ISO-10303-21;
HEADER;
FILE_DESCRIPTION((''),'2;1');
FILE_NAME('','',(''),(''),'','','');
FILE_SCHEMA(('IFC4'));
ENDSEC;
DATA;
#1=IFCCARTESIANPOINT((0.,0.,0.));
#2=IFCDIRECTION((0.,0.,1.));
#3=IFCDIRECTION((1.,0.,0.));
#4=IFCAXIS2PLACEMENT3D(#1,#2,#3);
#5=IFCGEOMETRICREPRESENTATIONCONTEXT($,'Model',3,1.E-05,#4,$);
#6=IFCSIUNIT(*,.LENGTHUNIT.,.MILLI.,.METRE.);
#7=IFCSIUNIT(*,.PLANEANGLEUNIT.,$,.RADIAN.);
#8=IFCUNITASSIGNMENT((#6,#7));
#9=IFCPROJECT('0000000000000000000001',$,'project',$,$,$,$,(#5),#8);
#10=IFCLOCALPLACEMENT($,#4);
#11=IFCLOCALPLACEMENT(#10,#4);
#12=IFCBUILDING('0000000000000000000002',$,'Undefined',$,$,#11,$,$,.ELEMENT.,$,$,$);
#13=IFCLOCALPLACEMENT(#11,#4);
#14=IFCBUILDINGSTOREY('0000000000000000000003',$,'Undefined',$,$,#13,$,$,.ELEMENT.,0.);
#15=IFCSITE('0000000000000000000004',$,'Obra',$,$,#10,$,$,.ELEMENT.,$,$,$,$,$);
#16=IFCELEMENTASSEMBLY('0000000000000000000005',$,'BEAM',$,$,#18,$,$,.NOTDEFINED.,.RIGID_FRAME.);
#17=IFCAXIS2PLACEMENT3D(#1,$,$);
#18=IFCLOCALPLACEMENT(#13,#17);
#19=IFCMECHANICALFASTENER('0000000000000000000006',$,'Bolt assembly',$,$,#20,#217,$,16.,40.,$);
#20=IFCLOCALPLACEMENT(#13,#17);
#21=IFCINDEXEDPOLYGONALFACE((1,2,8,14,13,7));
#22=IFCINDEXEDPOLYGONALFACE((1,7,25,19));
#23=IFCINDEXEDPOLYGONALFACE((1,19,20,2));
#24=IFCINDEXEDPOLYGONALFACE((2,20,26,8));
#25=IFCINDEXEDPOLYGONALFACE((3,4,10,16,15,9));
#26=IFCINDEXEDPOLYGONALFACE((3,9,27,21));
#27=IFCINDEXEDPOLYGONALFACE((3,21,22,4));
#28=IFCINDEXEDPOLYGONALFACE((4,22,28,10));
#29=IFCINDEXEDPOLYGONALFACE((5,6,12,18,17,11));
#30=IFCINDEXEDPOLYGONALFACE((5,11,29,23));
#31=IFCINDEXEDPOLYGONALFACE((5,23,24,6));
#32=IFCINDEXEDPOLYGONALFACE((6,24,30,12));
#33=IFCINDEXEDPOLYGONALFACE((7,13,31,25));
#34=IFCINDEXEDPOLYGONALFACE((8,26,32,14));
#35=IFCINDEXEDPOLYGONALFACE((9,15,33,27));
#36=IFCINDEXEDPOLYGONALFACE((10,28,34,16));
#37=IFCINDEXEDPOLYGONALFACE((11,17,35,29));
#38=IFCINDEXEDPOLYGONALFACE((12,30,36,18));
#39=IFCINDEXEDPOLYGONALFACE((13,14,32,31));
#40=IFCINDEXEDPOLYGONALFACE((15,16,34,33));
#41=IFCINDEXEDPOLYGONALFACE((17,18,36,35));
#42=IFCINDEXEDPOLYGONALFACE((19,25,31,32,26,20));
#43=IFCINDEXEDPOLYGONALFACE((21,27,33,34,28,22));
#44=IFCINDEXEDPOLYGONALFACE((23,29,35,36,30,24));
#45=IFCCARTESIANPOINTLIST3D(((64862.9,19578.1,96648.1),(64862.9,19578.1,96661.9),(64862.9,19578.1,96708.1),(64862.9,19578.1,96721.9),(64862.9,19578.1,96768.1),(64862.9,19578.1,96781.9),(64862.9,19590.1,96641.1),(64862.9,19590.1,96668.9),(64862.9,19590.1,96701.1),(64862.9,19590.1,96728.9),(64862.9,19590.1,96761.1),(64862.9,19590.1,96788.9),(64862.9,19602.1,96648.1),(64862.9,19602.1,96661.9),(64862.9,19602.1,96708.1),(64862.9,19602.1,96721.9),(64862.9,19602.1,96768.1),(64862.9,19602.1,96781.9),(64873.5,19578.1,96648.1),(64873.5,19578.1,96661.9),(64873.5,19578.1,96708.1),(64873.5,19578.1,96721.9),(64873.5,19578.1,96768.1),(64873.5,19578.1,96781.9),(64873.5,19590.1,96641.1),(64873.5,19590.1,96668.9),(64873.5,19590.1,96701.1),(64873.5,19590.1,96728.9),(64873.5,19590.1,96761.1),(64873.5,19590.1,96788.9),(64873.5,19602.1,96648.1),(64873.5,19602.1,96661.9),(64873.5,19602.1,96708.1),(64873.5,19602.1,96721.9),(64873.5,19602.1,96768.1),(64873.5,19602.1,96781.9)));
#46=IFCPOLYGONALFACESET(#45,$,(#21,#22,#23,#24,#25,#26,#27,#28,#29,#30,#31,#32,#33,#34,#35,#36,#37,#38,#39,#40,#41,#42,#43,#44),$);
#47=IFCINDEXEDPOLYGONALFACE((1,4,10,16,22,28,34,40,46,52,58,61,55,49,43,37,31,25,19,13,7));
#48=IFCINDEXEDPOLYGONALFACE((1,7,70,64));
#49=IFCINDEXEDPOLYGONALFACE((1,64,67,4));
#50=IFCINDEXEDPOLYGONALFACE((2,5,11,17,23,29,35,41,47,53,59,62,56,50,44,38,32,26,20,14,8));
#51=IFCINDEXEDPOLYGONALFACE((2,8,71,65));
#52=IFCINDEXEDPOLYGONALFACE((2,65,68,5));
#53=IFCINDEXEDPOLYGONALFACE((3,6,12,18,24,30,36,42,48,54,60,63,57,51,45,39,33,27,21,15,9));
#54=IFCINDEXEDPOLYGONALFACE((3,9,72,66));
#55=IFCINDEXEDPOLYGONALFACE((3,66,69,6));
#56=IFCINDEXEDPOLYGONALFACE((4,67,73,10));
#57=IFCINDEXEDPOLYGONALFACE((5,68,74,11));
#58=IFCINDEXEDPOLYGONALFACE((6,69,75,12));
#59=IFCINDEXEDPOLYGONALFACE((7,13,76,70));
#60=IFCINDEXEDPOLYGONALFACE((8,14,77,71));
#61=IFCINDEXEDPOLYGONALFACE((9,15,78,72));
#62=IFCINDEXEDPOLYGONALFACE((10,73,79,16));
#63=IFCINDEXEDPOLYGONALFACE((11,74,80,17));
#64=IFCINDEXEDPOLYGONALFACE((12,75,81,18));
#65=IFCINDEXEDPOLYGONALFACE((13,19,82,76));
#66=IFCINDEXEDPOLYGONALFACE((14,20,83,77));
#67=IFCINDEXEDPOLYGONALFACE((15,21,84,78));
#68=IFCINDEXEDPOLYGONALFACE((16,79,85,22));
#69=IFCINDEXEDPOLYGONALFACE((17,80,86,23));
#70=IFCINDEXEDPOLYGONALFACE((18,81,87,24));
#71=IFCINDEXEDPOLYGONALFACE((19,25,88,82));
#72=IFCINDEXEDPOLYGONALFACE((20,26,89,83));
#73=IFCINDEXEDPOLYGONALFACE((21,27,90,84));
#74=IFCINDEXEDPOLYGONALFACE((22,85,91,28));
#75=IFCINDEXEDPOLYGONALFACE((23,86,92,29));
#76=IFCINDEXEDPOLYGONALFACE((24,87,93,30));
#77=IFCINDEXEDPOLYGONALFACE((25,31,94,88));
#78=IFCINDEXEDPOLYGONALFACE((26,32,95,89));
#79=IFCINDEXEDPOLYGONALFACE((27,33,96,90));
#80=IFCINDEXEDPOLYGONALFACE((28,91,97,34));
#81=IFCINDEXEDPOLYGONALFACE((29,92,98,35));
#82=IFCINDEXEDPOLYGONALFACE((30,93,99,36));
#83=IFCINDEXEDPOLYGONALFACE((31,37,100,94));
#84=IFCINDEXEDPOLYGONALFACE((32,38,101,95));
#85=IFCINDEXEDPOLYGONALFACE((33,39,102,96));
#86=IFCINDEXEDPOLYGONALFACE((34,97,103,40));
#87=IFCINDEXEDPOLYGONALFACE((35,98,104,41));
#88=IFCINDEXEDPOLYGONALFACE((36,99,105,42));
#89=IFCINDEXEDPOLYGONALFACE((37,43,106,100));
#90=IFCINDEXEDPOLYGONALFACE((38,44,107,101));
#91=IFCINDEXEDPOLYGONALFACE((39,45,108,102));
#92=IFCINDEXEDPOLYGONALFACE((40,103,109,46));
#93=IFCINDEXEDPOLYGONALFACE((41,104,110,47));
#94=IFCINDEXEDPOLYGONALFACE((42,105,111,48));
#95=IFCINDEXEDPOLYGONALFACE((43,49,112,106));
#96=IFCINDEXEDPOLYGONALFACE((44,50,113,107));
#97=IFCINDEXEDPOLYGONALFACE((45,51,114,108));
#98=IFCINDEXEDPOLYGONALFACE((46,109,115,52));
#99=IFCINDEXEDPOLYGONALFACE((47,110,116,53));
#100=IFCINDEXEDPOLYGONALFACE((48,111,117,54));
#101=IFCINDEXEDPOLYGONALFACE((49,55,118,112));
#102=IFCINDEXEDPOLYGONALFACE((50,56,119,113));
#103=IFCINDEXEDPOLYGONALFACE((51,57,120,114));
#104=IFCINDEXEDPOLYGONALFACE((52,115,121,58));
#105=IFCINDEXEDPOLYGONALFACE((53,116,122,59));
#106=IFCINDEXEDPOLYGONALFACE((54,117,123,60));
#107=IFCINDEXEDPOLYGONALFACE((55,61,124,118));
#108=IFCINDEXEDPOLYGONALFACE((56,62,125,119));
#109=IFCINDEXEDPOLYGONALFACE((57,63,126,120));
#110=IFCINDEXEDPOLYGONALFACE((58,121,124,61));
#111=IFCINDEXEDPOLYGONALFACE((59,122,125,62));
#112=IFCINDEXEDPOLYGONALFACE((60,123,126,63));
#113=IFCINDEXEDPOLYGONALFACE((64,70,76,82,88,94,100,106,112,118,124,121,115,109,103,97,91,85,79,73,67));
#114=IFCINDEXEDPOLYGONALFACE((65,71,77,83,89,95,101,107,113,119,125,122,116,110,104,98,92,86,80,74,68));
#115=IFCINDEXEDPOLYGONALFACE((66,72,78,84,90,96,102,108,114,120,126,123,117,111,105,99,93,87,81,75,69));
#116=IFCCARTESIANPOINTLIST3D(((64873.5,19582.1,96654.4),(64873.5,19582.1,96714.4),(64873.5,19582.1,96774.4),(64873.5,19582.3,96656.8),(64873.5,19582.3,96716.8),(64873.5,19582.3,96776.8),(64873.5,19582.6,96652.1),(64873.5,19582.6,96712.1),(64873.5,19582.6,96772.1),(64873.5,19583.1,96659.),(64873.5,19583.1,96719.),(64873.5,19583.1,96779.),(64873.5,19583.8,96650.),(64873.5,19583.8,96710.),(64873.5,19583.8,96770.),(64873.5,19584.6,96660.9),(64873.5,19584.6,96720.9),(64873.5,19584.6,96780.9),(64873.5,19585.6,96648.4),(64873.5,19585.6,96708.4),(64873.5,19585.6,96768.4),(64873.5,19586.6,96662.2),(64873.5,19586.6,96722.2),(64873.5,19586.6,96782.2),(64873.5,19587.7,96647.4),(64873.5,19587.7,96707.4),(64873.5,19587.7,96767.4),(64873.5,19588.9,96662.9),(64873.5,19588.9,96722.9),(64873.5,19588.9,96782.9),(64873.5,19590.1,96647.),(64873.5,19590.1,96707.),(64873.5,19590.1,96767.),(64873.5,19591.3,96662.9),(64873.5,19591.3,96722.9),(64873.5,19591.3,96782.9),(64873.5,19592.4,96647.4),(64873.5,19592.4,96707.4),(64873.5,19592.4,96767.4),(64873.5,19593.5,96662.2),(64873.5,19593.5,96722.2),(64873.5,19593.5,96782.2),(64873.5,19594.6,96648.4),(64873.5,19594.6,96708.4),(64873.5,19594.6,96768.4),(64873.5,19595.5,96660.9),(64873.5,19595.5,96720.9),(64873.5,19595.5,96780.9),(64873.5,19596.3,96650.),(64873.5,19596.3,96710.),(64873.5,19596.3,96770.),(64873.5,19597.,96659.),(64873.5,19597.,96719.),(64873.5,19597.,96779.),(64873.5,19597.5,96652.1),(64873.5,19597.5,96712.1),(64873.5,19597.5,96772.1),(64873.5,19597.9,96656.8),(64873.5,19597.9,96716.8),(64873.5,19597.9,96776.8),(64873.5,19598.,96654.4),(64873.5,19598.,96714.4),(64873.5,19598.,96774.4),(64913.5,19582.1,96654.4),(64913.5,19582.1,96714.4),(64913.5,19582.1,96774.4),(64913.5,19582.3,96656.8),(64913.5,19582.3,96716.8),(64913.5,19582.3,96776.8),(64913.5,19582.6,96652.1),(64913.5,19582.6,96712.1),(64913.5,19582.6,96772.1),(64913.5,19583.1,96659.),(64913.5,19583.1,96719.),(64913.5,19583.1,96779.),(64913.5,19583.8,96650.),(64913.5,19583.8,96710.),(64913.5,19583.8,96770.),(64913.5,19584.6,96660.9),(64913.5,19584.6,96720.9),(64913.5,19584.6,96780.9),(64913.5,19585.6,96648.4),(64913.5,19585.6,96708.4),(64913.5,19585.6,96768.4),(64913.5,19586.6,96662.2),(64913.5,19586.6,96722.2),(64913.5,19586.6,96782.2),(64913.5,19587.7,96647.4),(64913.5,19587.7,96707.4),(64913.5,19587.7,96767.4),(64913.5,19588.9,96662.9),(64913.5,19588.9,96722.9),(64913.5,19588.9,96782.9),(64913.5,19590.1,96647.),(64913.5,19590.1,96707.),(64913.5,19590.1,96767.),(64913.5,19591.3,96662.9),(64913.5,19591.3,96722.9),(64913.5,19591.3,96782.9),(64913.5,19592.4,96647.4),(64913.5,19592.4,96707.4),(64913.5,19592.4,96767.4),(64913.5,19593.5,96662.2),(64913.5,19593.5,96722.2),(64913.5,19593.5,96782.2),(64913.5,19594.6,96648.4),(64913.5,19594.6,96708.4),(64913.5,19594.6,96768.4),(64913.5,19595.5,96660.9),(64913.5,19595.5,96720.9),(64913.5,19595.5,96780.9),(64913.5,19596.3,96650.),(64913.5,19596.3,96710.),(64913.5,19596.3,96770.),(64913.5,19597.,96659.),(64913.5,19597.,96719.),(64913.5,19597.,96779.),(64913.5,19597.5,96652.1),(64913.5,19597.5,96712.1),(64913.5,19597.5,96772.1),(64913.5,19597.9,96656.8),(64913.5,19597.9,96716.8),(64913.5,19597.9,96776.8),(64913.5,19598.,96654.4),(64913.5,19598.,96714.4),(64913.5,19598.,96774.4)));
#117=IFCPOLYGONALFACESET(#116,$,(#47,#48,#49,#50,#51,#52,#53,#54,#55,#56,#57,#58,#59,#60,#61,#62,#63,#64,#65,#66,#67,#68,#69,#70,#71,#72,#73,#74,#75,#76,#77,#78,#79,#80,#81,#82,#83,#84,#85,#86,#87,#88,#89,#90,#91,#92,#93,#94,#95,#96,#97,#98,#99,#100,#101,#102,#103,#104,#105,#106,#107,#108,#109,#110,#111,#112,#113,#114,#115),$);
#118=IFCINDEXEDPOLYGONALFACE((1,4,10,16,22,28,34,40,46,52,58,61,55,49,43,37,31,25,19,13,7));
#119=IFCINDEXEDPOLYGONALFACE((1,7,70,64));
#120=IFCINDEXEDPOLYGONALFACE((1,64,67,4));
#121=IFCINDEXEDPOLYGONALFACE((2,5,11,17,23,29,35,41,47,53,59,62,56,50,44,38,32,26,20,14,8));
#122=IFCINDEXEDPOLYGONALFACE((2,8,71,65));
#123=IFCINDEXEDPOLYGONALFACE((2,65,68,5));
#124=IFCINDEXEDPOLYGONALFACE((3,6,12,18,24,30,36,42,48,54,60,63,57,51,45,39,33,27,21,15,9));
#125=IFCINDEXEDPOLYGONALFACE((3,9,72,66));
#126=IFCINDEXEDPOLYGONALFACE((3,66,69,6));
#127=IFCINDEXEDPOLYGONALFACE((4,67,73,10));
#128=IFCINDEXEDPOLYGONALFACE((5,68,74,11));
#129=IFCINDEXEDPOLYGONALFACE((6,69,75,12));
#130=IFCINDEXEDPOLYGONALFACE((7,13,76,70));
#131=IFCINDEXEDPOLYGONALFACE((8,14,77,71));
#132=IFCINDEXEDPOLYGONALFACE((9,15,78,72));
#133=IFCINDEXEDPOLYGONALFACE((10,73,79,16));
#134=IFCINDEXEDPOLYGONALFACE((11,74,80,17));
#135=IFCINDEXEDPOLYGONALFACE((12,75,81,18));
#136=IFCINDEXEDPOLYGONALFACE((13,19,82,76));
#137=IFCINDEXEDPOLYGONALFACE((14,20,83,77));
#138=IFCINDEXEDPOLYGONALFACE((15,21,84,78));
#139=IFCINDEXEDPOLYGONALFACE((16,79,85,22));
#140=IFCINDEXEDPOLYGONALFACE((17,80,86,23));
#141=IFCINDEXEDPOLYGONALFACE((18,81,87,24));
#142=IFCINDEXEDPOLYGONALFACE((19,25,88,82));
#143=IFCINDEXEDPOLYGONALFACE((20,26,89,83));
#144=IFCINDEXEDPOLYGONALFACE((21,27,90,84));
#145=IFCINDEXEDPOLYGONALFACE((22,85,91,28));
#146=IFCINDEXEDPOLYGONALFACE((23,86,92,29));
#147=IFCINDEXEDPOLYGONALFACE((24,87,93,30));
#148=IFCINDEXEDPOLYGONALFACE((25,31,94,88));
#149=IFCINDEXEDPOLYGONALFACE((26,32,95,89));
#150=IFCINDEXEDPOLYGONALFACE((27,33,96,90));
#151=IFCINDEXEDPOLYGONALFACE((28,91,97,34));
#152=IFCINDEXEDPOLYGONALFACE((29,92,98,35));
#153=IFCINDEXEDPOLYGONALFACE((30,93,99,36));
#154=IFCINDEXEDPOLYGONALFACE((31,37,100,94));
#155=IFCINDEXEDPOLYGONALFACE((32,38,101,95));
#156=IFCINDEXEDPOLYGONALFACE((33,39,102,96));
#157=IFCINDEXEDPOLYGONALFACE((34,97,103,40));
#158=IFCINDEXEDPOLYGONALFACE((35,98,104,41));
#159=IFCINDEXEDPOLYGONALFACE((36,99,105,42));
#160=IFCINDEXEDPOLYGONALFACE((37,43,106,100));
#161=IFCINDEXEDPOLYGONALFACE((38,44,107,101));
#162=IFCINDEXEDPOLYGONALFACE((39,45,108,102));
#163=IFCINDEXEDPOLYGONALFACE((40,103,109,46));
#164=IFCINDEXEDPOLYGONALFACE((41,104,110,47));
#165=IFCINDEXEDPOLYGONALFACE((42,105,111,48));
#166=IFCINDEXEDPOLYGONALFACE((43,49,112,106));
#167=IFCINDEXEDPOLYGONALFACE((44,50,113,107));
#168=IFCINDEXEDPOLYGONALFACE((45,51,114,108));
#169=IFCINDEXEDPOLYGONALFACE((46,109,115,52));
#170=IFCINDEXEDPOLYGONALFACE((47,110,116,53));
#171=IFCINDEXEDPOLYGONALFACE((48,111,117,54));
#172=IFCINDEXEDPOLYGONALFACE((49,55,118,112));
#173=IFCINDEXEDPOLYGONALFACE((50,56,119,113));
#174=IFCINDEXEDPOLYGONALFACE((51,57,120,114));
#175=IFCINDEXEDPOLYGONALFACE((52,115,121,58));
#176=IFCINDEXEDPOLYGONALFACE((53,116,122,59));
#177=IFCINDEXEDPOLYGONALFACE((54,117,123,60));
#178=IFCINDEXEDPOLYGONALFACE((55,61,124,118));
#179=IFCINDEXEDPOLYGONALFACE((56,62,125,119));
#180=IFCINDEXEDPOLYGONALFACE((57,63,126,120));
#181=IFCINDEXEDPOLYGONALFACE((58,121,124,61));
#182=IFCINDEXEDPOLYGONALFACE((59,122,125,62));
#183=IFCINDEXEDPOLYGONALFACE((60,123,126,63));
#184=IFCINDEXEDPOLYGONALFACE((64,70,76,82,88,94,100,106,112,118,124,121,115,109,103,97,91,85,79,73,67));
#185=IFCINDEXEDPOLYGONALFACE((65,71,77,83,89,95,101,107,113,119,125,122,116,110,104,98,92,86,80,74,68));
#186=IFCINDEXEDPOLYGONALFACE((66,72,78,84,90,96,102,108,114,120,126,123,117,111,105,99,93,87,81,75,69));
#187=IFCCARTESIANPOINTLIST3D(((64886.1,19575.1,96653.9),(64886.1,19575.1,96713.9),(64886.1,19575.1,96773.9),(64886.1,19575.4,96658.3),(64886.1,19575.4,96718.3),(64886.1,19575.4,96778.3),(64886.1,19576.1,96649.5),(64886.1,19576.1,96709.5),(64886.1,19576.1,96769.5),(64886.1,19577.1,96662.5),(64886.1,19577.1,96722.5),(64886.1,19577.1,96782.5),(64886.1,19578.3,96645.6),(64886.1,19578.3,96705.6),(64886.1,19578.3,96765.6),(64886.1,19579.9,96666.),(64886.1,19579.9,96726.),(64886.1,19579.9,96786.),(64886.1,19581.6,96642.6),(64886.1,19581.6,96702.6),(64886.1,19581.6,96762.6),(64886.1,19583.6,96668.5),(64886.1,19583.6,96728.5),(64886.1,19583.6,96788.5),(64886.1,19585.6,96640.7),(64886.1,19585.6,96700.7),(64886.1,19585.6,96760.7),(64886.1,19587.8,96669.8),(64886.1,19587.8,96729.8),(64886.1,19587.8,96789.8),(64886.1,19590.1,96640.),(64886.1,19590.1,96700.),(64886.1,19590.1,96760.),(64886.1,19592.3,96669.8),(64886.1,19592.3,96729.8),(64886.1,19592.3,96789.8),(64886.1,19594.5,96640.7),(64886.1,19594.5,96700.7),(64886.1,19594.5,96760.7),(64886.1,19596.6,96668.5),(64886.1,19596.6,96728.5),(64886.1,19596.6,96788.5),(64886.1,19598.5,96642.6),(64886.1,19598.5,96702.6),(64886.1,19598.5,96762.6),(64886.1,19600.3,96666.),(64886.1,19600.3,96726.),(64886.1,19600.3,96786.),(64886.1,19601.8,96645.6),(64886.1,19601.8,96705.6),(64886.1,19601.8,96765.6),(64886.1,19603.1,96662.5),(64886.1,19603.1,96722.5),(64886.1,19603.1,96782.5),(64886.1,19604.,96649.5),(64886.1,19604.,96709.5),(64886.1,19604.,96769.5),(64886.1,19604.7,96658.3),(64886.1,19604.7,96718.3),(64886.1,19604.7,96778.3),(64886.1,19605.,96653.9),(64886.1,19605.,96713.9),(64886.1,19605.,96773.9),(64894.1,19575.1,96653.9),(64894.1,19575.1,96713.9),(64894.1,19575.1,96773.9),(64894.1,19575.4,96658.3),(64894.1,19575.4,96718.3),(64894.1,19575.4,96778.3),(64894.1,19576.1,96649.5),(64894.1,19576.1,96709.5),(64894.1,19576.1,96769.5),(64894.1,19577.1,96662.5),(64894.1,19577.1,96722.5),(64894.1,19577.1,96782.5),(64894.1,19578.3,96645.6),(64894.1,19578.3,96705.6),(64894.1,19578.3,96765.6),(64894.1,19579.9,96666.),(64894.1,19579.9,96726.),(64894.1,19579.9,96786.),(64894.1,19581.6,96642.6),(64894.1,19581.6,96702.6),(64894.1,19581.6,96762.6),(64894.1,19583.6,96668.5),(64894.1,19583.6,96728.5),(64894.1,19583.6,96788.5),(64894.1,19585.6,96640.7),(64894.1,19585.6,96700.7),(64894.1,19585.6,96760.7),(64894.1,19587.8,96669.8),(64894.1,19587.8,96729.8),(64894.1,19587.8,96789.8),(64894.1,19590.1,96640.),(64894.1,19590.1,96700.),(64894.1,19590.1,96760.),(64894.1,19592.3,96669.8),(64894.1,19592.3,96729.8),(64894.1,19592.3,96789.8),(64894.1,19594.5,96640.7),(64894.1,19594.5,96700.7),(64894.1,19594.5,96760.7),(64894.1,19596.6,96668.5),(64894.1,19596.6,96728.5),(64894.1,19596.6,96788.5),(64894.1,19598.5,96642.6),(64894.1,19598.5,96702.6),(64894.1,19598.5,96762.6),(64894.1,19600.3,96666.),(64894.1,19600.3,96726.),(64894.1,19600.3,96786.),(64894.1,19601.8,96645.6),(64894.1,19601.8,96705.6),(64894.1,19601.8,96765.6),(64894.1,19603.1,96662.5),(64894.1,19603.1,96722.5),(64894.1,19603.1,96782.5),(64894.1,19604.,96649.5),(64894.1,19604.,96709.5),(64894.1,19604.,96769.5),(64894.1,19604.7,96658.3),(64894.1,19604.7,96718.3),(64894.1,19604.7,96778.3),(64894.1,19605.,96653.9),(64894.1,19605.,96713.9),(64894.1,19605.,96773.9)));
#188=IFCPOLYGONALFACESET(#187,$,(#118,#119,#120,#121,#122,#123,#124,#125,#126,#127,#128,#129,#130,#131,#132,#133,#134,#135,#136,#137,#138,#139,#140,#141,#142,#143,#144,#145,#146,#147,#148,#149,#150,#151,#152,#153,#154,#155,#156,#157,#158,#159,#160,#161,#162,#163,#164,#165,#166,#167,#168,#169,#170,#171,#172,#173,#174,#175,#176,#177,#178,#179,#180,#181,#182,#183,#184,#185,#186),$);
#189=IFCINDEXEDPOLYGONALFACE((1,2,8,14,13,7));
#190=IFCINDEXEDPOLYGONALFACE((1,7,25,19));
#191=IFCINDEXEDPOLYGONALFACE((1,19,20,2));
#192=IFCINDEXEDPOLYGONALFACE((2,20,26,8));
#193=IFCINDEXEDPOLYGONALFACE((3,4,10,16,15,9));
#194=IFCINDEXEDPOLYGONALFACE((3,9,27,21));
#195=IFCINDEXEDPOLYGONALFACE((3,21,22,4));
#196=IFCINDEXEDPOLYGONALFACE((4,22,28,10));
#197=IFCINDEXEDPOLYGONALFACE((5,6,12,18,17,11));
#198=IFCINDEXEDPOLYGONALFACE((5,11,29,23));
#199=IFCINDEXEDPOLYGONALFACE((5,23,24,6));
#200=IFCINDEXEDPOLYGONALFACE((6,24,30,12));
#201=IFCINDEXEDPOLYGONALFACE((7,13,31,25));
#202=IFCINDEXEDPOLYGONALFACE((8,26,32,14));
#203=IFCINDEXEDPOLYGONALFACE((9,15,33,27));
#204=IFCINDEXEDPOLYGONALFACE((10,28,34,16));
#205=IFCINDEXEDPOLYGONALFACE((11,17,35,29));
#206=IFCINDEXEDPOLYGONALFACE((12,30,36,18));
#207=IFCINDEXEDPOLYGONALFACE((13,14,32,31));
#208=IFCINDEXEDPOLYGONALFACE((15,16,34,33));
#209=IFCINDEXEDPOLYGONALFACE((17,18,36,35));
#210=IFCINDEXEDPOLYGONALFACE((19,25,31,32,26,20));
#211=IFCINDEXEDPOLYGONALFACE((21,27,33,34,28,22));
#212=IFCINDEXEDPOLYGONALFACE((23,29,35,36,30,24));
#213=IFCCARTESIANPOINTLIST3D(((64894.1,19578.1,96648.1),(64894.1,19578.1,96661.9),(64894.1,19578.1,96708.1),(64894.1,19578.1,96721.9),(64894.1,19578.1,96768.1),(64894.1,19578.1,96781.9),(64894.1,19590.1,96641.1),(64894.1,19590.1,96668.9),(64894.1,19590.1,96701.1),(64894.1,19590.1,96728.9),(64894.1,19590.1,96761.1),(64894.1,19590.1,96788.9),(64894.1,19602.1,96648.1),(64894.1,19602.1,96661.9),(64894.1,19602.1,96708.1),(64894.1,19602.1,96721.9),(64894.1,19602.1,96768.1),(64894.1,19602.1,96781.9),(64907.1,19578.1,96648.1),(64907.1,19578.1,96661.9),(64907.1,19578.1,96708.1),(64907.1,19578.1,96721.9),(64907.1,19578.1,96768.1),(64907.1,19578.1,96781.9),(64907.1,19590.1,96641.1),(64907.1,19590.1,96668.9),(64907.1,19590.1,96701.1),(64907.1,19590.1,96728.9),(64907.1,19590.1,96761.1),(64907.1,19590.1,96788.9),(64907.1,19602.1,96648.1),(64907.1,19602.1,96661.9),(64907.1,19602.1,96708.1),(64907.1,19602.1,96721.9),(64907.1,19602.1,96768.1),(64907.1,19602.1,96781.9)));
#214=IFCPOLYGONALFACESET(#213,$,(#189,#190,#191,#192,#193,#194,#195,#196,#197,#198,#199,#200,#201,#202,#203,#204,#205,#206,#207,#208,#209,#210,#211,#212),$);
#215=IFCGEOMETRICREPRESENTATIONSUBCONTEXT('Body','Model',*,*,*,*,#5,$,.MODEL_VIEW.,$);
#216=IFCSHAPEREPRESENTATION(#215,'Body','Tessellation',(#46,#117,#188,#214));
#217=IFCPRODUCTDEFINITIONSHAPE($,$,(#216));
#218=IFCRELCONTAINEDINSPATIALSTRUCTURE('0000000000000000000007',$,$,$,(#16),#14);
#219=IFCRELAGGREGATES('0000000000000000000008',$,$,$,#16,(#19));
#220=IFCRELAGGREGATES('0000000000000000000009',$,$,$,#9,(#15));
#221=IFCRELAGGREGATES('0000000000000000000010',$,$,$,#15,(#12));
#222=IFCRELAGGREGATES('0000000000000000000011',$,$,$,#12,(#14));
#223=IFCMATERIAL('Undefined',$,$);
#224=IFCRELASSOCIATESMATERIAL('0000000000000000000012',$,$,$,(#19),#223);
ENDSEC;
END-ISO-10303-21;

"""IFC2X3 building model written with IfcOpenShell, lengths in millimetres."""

from ifc_helpers import new_model, si_unit, frame, origin_with_axes, origin_2d_with_axis, place, context, subcontext, project, spatial, polyline, circle, outline, extrude, source, transform, mapped, material, element, aggregate, save


model = new_model("IFC2X3")

# Units and contexts
model_context = context("Model", 3, precision=1e-05, world=origin_with_axes())
body_context = subcontext(model_context, "Body", "Model", "MODEL_VIEW")
ifc_project = project(units=[si_unit("LENGTHUNIT", "METRE", prefix="MILLI"), si_unit("PLANEANGLEUNIT", "RADIAN")], contexts=[model_context])

# Site, building, storey
site_placement = place(None, origin_with_axes())
site = spatial("IfcSite", under=ifc_project, at=site_placement, Name="Obra", CompositionType="ELEMENT")
building_placement = place(site_placement, origin_with_axes())
building = spatial("IfcBuilding", under=site, at=building_placement, Name="Undefined", CompositionType="ELEMENT")
storey_placement = place(building_placement, origin_with_axes())
storey = spatial("IfcBuildingStorey", under=building, at=storey_placement, Name="Undefined", CompositionType="ELEMENT", Elevation=0.0)

# Element assembly, mechanical fastener
assembly_1_placement = place(storey_placement, origin_with_axes())
assembly_1 = element("IfcElementAssembly", 1, at=assembly_1_placement, inside=storey, Name="BEAM", AssemblyPlace="NOTDEFINED", PredefinedType="RIGID_FRAME")
ifc_material_1 = material(Name="Undefined")
shared_shape_1 = source(origin_with_axes(), body_context, "Body", "SweptSolid", [
    extrude(outline(polyline([(13.9, 0.0), (6.9, 12.0), (-6.9, 12.0), (-13.9, 0.0), (-6.9, -12.0), (6.9, -12.0), (13.9, 0.0)])), frame((0.0, -19.9, 0.0), z_axis=(0.0, 1.0, 0.0), x_axis=(1.0, 0.0, 0.0)), (0.0, 0.0, 1.0), 10.6),
    extrude(circle(Radius=8.0, at=origin_2d_with_axis()), frame((0.0, -9.3, 0.0), z_axis=(0.0, 1.0, 0.0), x_axis=(1.0, 0.0, 0.0)), (0.0, 0.0, 1.0), 40.0),
    extrude(circle(Radius=15.0, at=origin_2d_with_axis()), frame((0.0, 3.3, 0.0), z_axis=(0.0, 1.0, 0.0), x_axis=(1.0, 0.0, 0.0)), (0.0, 0.0, 1.0), 8.0),
    extrude(outline(polyline([(13.9, 0.0), (6.9, 12.0), (-6.9, 12.0), (-13.9, 0.0), (-6.9, -12.0), (6.9, -12.0), (13.9, 0.0)])), frame((0.0, 11.3, 0.0), z_axis=(0.0, 1.0, 0.0), x_axis=(1.0, 0.0, 0.0)), (0.0, 0.0, 1.0), 13.0),
])
mechanical_fastener_1_placement = place(assembly_1_placement, frame((64882.8, 19640.1, 96850.0), z_axis=(0.000002, -1.0, 0.0), x_axis=(0.0, 0.0, -1.0)))
mechanical_fastener_1 = element("IfcMechanicalFastener", 2, at=mechanical_fastener_1_placement, material=ifc_material_1, Name="Bolt assembly", NominalDiameter=16.0, NominalLength=40.0, context=body_context, shape_type="MappedRepresentation", body=[
    mapped(shared_shape_1, transform((75.0, 0.0, 50.0))),
    mapped(shared_shape_1, transform((135.0, 0.0, 50.0))),
    mapped(shared_shape_1, transform((195.0, 0.0, 50.0))),
])
aggregate(assembly_1, [mechanical_fastener_1])

save(model, "model.ifc")
